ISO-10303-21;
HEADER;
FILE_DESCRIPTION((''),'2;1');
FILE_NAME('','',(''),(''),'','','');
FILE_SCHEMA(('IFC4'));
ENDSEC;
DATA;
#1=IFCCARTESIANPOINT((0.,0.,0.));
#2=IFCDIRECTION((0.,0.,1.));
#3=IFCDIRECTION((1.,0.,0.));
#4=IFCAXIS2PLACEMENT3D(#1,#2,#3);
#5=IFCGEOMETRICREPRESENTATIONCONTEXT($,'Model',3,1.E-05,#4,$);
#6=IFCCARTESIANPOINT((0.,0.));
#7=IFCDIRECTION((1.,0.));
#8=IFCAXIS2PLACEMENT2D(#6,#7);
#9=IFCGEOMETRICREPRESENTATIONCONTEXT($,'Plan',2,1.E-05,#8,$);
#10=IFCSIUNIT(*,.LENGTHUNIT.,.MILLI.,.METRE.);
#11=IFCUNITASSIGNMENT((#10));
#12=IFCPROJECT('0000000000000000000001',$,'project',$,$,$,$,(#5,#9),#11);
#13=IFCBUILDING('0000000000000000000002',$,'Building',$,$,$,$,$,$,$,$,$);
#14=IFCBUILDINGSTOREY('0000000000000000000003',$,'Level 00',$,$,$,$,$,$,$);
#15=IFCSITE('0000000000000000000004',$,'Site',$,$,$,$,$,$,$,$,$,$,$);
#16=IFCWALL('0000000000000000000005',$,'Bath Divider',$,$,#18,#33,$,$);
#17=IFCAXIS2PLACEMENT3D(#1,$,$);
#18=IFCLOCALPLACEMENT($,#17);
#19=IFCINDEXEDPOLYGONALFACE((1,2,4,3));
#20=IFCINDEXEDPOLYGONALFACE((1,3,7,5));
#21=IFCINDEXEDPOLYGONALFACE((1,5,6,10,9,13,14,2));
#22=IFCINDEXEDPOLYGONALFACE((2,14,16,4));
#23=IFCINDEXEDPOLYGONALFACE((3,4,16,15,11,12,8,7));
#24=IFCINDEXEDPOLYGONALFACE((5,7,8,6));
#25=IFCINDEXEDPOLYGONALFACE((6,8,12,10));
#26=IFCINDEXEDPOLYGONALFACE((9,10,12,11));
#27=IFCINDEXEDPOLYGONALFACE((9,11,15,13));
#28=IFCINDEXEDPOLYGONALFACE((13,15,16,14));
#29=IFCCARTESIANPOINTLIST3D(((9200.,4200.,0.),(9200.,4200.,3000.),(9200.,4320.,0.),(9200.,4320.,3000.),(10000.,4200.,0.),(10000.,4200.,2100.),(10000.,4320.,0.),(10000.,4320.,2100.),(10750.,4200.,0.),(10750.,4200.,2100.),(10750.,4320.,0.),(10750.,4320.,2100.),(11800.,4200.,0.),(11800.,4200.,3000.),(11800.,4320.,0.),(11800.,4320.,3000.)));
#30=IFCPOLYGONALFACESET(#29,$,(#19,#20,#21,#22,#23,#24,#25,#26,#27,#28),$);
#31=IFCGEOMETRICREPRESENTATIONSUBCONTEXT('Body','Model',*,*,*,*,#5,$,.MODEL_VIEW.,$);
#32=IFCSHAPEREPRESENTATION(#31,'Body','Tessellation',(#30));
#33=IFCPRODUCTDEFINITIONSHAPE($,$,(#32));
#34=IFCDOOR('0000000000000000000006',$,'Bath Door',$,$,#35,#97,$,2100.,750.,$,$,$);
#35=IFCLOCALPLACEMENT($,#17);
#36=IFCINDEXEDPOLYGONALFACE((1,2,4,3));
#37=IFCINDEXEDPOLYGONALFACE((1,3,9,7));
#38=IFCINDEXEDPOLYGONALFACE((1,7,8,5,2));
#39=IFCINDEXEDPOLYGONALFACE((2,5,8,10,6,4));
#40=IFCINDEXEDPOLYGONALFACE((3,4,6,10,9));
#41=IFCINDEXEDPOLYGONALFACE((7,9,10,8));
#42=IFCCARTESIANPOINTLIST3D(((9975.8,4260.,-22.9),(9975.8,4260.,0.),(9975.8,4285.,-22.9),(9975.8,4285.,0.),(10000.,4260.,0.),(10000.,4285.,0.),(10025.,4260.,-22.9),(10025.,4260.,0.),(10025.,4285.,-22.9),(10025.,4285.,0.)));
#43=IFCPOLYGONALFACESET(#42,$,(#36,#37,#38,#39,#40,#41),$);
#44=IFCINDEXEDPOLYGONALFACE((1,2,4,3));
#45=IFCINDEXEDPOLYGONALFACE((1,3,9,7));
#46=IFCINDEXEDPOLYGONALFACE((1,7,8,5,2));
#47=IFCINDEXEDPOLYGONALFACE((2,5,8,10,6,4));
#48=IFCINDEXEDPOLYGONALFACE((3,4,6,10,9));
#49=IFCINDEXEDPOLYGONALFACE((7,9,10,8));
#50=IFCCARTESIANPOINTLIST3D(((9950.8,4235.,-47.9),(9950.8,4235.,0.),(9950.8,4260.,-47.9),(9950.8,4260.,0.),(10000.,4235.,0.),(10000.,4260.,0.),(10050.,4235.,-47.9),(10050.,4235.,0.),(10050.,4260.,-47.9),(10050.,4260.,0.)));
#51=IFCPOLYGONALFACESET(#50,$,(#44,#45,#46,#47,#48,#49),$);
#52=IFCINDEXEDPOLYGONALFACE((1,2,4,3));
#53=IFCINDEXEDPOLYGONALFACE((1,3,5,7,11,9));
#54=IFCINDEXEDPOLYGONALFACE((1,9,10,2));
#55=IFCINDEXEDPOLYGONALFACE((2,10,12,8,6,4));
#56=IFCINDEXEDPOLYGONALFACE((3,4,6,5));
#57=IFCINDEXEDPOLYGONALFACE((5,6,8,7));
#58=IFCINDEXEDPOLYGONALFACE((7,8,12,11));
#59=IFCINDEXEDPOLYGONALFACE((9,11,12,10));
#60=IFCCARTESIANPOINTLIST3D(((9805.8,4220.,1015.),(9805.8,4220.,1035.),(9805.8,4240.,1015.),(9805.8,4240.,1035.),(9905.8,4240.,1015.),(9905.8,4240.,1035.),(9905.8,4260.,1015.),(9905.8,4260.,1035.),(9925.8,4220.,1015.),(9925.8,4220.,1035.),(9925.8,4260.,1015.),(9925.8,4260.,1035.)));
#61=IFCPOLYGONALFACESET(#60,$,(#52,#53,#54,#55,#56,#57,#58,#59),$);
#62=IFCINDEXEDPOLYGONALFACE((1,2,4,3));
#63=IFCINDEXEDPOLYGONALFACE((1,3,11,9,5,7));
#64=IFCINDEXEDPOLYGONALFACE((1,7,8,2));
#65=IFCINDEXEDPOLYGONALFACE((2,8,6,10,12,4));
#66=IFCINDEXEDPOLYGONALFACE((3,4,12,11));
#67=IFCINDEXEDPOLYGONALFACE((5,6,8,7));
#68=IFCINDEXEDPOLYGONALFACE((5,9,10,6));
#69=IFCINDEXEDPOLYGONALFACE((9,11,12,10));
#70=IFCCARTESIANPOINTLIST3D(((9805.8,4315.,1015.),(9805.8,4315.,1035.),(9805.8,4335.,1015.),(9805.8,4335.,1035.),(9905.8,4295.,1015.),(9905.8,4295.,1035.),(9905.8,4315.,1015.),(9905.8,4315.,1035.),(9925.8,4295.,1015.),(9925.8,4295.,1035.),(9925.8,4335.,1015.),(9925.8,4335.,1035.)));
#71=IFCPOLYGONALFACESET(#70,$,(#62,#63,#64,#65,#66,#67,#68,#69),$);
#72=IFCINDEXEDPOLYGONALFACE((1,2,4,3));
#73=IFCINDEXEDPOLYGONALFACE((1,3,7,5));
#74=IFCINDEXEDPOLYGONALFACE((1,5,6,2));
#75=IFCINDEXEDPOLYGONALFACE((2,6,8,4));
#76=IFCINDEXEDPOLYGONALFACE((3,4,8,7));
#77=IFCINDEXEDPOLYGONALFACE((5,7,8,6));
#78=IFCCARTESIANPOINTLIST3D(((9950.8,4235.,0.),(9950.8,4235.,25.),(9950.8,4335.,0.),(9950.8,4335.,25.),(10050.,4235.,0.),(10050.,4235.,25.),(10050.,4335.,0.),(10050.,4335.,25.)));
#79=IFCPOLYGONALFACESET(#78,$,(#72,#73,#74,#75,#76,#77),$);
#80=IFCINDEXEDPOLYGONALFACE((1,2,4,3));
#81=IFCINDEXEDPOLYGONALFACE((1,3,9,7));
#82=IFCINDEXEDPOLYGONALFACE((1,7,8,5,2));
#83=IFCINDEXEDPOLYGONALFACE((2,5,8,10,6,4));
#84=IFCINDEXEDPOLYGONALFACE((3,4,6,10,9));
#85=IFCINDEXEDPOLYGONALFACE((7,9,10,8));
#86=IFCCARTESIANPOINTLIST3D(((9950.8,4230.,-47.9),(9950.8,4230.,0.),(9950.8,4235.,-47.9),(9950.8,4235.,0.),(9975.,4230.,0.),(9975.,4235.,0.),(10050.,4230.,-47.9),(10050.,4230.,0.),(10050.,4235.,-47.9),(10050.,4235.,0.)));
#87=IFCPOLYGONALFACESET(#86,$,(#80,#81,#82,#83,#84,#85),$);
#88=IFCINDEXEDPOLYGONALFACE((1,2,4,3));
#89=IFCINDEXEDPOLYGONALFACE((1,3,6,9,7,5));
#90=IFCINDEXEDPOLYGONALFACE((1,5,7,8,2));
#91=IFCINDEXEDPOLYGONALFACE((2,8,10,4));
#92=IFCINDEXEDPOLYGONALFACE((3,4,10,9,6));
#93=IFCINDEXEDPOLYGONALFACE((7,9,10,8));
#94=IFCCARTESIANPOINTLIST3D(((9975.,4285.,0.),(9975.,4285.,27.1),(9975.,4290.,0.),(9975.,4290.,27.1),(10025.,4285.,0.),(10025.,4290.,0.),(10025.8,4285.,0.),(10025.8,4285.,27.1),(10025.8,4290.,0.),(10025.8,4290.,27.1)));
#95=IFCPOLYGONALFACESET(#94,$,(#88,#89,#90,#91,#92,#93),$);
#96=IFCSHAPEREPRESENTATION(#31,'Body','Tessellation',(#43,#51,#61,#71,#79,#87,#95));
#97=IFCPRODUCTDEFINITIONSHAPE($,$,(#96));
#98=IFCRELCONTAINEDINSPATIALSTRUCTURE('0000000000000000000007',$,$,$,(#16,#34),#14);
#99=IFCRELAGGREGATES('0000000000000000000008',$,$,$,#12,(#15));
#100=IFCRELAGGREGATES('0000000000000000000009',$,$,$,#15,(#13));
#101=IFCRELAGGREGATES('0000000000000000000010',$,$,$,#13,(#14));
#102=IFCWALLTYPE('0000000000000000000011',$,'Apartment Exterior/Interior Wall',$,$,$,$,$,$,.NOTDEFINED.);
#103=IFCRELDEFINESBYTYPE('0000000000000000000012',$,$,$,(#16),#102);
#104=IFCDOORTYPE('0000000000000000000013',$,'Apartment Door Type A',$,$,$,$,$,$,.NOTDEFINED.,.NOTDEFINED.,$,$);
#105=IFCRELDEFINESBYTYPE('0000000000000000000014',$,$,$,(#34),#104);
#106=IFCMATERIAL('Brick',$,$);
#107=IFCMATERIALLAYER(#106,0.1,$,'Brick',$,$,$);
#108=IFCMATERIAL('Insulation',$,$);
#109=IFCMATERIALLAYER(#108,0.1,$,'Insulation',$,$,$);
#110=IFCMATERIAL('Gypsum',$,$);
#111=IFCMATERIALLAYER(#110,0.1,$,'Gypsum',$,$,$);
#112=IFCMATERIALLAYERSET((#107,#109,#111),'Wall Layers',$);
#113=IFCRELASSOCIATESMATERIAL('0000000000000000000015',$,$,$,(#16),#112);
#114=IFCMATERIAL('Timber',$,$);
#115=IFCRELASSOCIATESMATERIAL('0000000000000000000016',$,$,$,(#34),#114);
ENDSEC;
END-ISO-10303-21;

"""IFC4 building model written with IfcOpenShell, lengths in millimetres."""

from ifc_helpers import new_model, si_unit, frame, origin_with_axes, origin_2d_with_axis, place, context, subcontext, project, spatial, line, indexed_curve, outline, extrude, material, layer, layer_set, layer_usage, type_object, element, fill, save


model = new_model("IFC4")

# Units and contexts
model_context = context("Model", 3, precision=1e-05, world=origin_with_axes())
plan_context = context("Plan", 2, precision=1e-05, world=origin_2d_with_axis())
body_context = subcontext(model_context, "Body", "Model", "MODEL_VIEW")
ifc_project = project(units=[si_unit("LENGTHUNIT", "METRE", prefix="MILLI")], contexts=[model_context, plan_context])

# Site, building, storey
site = spatial("IfcSite", under=ifc_project, Name="Site")
building = spatial("IfcBuilding", under=site, Name="Building")
storey = spatial("IfcBuildingStorey", under=building, Name="Level 00")

# Shared definitions
ifc_material_1 = material(Name="Brick")
ifc_layer_1 = layer(ifc_material_1, 0.1, Name="Brick")
ifc_material_2 = material(Name="Insulation")
ifc_layer_2 = layer(ifc_material_2, 0.1, Name="Insulation")
ifc_material_3 = material(Name="Gypsum")
ifc_layer_3 = layer(ifc_material_3, 0.1, Name="Gypsum")
ifc_layer_set = layer_set([ifc_layer_1, ifc_layer_2, ifc_layer_3], Name="Wall Layers")
ifc_layer_usage = layer_usage(ifc_layer_set, "AXIS2", "POSITIVE", 0.0)
wall_type = type_object("IfcWallType", Name="Apartment Exterior/Interior Wall", PredefinedType="NOTDEFINED")
ifc_material_4 = material(Name="Timber")
door_type = type_object("IfcDoorType", Name="Apartment Door Type A", OperationType="NOTDEFINED", PredefinedType="NOTDEFINED")

# Wall, opening, door
wall_1_placement = place(None, frame((9200.0, 4200.0, 0.0), z_axis=(0.0, 0.0, 1.0), x_axis=(1.0, 0.0, 0.0)))
wall_1 = element("IfcWall", 1, at=wall_1_placement, inside=storey, type_object=wall_type, material=ifc_layer_usage, Name="Bath Divider", context=body_context, shape_type="SweptSolid", body=[
    extrude(outline(indexed_curve([(0.0, 0.0), (0.0, 120.0), (2600.0, 120.0), (2600.0, 0.0), (0.0, 0.0)], self_intersect=False)), origin_with_axes(), (0.0, 0.0, 1.0), 3000.0),
])
opening_1_placement = place(wall_1_placement, frame((800.0, -12.0, 0.0), z_axis=(0.0, 0.0, 1.0), x_axis=(1.0, 0.0, 0.0)))
opening_1 = element("IfcOpeningElement", 2, at=opening_1_placement, cuts=wall_1, context=body_context, shape_type="SweptSolid", body=[
    extrude(outline(indexed_curve([(0.0, 0.0), (0.0, 144.0), (750.0, 144.0), (750.0, 0.0), (0.0, 0.0)], self_intersect=False)), origin_with_axes(), (0.0, 0.0, 1.0), 2100.0),
])
door_1_placement = place(opening_1_placement, frame((0.0, 47.0, 0.0), z_axis=(0.0, 0.0, 1.0), x_axis=(1.0, 0.0, 0.0)))
door_1 = element("IfcDoor", 3, at=door_1_placement, inside=storey, type_object=door_type, material=ifc_material_4, Name="Bath Door", OverallHeight=2100.0, OverallWidth=750.0, context=body_context, shape_type="SweptSolid", body=[
    extrude(outline(indexed_curve([(0.0, 0.0), (0.0, 2.1), (0.8, 2.1), (0.8, 0.0), (-24.2, 0.0), (-24.2, -22.9), (25.0, -22.9), (25.0, 0.0)], segments=[line(1, 2, 3, 4, 5, 6, 7, 8, 1)])), frame((0.0, 25.0, 0.0), z_axis=(0.0, -1.0, 0.0), x_axis=(1.0, 0.0, 0.0)), (0.0, 0.0, -1.0), 25.0),
    extrude(outline(indexed_curve([(0.0, 0.0), (0.0, 2.1), (0.8, 2.1), (0.8, 0.0), (-49.2, 0.0), (-49.2, -47.9), (50.0, -47.9), (50.0, 0.0)], segments=[line(1, 2, 3, 4, 5, 6, 7, 8, 1)])), frame((0.0, 0.0, 0.0), z_axis=(0.0, -1.0, 0.0), x_axis=(1.0, 0.0, 0.0)), (0.0, 0.0, -1.0), 25.0),
    extrude(outline(indexed_curve([(0.0, 0.0), (-49.2, 0.0), (-49.2, 35.0), (0.0, 35.0)], segments=[line(1, 2, 3, 4, 1)])), frame((25.0, 25.0, 25.0), z_axis=(0.0, 0.0, 1.0), x_axis=(1.0, 0.0, 0.0)), (0.0, 0.0, 1.0), -47.9),
    extrude(outline(indexed_curve([(0.0, 0.0), (0.0, -40.0), (-120.0, -40.0), (-120.0, -20.0), (-20.0, -20.0), (-20.0, 0.0)], segments=[line(1, 2, 3, 4, 5, 6, 1)])), frame((-74.2, 25.0, 1015.0), z_axis=(0.0, 0.0, 1.0), x_axis=(1.0, 0.0, 0.0)), (0.0, 0.0, 1.0), 20.0),
    extrude(outline(indexed_curve([(0.0, 0.0), (0.0, 40.0), (-120.0, 40.0), (-120.0, 20.0), (-20.0, 20.0), (-20.0, 0.0)], segments=[line(1, 2, 3, 4, 5, 6, 1)])), frame((-74.2, 60.0, 1015.0), z_axis=(0.0, 0.0, 1.0), x_axis=(1.0, 0.0, 0.0)), (0.0, 0.0, 1.0), 20.0),
    extrude(outline(indexed_curve([(0.0, 0.0), (-99.2, 0.0), (-99.2, 100.0), (0.0, 100.0)], segments=[line(1, 2, 3, 4, 1)])), frame((50.0, 0.0, 0.0), z_axis=(0.0, 0.0, 1.0), x_axis=(1.0, 0.0, 0.0)), (0.0, 0.0, 1.0), 25.0),
    extrude(outline(indexed_curve([(0.0, 0.0), (0.0, 27.1), (50.8, 27.1), (50.8, 0.0), (-24.2, 0.0), (-24.2, -47.9), (75.0, -47.9), (75.0, 0.0)], segments=[line(1, 2, 3, 4, 5, 6, 7, 8, 1)])), frame((-25.0, -5.0, 0.0), z_axis=(0.0, -1.0, 0.0), x_axis=(1.0, 0.0, 0.0)), (0.0, 0.0, -1.0), 5.0),
    extrude(outline(indexed_curve([(0.0, 0.0), (0.0, 27.1), (50.8, 27.1), (50.8, 0.0), (0.8, 0.0), (0.8, -22.9), (50.0, -22.9), (50.0, 0.0)], segments=[line(1, 2, 3, 4, 5, 6, 7, 8, 1)])), frame((-25.0, 50.0, 0.0), z_axis=(0.0, -1.0, 0.0), x_axis=(1.0, 0.0, 0.0)), (0.0, 0.0, -1.0), 5.0),
])
fill(opening_1, door_1)

save(model, "model.ifc")
